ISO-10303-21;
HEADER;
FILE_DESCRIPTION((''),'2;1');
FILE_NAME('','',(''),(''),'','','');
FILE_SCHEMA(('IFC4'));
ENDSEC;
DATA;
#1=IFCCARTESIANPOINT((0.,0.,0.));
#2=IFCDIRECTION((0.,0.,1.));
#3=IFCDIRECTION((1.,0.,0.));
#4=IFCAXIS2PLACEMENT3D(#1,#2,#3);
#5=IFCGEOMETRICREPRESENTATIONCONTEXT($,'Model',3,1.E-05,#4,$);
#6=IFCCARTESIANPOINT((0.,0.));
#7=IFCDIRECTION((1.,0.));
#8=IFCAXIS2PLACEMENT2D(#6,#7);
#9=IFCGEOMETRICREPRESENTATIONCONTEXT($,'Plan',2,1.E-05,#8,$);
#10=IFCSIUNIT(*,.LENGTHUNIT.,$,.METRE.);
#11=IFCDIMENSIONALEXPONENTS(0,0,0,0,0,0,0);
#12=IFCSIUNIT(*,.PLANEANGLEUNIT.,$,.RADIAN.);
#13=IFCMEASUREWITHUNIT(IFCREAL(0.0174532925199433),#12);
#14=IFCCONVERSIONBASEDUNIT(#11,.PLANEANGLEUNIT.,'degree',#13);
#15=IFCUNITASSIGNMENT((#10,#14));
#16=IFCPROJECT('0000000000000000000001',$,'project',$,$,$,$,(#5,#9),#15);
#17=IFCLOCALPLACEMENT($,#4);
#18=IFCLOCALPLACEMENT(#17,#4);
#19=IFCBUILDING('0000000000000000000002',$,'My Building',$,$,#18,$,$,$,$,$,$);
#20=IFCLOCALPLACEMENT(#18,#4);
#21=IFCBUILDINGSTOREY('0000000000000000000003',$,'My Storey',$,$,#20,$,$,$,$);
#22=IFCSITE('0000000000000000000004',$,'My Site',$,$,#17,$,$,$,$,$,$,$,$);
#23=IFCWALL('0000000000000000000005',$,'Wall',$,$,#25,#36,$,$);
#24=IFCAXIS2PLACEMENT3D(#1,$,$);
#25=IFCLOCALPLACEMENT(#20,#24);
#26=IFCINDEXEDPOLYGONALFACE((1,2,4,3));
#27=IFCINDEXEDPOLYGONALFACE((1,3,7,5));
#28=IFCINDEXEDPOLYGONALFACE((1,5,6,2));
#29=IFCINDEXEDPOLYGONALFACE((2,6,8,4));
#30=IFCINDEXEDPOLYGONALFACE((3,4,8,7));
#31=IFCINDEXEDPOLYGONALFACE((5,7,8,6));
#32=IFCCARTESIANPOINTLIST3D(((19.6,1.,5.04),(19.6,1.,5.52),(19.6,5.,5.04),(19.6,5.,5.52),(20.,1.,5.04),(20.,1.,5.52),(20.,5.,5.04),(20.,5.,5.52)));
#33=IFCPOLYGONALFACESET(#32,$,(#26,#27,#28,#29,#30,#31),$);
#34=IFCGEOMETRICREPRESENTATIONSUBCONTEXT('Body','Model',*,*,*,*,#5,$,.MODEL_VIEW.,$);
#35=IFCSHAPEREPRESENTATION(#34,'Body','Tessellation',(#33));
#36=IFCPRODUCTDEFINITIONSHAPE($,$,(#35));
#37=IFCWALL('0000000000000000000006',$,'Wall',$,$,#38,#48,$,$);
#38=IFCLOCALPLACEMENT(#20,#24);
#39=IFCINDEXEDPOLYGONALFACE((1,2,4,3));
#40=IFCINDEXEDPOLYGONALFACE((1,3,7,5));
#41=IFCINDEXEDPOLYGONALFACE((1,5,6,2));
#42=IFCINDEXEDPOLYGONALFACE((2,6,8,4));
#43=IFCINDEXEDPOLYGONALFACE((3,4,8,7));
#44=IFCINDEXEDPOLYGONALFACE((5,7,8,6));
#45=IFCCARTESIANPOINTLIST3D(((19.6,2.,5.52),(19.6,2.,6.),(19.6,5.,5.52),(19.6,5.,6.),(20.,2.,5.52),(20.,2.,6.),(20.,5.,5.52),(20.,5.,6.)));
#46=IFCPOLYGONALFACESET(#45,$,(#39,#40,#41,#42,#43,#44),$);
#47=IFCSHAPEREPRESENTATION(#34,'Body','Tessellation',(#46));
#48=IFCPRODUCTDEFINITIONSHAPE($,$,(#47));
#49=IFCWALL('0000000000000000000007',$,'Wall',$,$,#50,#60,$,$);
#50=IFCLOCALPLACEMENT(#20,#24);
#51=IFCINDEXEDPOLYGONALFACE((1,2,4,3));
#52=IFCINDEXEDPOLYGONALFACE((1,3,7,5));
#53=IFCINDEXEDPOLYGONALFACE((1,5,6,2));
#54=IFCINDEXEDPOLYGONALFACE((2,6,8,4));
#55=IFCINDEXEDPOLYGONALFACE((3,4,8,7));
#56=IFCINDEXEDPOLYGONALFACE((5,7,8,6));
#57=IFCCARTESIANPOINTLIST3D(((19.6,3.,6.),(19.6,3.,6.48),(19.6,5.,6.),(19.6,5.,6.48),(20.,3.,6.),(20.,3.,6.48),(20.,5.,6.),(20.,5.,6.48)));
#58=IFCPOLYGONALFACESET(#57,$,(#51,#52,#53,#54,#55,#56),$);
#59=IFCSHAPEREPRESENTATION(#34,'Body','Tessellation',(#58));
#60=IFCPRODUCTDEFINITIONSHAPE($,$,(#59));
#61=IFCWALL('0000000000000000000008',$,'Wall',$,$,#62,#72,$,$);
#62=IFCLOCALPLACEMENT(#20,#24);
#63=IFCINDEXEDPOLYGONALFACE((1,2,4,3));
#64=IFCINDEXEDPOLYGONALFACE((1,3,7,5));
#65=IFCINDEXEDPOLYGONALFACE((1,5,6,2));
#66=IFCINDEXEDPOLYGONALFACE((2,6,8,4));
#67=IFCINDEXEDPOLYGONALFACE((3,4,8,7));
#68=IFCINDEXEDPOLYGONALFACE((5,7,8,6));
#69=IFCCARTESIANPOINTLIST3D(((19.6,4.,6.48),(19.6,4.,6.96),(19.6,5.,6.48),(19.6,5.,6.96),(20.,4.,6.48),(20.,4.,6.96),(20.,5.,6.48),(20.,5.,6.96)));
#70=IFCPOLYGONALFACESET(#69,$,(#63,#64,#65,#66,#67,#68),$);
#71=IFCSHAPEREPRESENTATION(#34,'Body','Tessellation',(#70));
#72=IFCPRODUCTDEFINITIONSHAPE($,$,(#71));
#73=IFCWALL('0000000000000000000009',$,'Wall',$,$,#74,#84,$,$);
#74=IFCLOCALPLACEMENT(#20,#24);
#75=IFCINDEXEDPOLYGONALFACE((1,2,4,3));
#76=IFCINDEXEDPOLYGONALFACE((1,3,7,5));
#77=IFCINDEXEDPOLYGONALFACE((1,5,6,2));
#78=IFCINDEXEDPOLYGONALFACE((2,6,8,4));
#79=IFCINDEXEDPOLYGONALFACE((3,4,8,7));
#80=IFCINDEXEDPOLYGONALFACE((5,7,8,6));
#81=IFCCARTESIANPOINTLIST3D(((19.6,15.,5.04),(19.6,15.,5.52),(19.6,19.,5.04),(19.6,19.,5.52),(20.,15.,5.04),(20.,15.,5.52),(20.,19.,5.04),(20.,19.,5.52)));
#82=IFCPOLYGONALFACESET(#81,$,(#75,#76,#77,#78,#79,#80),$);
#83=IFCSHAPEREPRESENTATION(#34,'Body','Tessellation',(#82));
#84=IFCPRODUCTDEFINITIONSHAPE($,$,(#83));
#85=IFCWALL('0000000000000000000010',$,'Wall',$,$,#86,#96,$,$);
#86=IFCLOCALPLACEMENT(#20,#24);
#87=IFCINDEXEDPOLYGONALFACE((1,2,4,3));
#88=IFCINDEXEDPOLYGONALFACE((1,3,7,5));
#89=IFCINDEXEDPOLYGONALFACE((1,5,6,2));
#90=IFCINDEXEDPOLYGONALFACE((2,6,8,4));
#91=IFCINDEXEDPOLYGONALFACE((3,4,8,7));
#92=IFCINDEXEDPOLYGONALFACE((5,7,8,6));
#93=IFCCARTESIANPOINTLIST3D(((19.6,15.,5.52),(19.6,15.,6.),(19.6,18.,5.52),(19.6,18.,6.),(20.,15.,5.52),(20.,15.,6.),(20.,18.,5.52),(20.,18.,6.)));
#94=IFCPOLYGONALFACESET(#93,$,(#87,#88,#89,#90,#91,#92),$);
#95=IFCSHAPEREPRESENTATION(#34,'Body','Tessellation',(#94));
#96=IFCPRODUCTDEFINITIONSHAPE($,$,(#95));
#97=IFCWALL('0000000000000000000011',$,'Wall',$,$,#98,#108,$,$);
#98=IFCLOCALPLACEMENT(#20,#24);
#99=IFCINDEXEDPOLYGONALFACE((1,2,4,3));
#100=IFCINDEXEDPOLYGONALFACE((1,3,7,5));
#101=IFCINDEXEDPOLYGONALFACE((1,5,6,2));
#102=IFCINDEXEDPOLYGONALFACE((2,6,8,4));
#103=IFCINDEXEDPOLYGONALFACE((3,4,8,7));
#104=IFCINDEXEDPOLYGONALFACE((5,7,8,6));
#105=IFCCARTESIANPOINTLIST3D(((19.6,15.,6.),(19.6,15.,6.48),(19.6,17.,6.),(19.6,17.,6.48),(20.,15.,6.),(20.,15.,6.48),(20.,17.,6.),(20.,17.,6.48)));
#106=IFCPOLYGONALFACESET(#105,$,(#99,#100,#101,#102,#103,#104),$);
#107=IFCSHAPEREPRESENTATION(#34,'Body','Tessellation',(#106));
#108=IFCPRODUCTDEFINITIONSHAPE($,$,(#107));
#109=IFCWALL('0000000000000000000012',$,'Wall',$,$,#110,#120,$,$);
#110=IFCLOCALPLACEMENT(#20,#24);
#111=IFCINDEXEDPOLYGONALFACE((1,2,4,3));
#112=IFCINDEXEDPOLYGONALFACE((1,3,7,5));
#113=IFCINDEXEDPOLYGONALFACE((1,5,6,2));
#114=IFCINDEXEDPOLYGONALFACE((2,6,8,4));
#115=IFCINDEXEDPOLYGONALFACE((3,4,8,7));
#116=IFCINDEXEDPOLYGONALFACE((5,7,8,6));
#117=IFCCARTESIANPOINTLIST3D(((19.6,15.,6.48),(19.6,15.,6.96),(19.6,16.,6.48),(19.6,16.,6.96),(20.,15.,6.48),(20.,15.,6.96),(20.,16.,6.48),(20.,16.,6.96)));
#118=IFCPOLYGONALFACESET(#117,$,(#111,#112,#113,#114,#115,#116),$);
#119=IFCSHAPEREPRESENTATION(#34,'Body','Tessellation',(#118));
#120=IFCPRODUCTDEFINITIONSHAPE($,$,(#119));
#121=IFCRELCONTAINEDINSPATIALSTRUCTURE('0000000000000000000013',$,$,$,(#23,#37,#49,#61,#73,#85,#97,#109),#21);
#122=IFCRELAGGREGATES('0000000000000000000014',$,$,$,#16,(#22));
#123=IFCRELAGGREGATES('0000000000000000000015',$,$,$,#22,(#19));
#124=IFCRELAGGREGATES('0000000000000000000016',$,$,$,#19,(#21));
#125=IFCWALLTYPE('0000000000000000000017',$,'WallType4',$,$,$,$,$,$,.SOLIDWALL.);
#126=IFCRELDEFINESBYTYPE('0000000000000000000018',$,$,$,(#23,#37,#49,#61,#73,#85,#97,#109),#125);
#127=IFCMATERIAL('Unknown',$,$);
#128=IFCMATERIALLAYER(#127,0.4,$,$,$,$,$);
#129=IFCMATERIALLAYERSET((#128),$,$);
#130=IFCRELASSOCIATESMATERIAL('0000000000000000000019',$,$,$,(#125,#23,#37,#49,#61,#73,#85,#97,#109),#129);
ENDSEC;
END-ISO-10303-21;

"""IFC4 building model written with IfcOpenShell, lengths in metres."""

from ifc_helpers import new_model, entity, si_unit, converted_unit, frame, origin_with_axes, origin_2d_with_axis, place, context, subcontext, project, spatial, indexed_curve, outline, extrude, material, layer, layer_set, layer_usage, type_object, element, save


model = new_model("IFC4")

# Units and contexts
model_context = context("Model", 3, precision=1e-05, world=origin_with_axes())
plan_context = context("Plan", 2, precision=1e-05, world=origin_2d_with_axis())
body_context_1 = subcontext(model_context, "Body", "Model", "MODEL_VIEW")
ifc_project = project(units=[si_unit("LENGTHUNIT", "METRE"), converted_unit("PLANEANGLEUNIT", "degree", entity("IfcReal", 0.0174532925199433), si_unit("PLANEANGLEUNIT", "RADIAN"), dimensions=[0, 0, 0, 0, 0, 0, 0])], contexts=[model_context, plan_context])

# Site, building, storey
site_placement = place(None, origin_with_axes())
site = spatial("IfcSite", under=ifc_project, at=site_placement, Name="My Site")
building_placement = place(site_placement, origin_with_axes())
building = spatial("IfcBuilding", under=site, at=building_placement, Name="My Building")
storey_placement = place(building_placement, origin_with_axes())
storey = spatial("IfcBuildingStorey", under=building, at=storey_placement, Name="My Storey")

# Shared definitions
ifc_material = material(Name="Unknown")

# Shared definitions
ifc_layer_1 = layer(ifc_material, 0.4)
ifc_layer_set_1 = layer_set([ifc_layer_1])
wall_type_1 = type_object("IfcWallType", Name="WallType4", PredefinedType="SOLIDWALL", material=ifc_layer_set_1)

# Walls
ifc_layer_usage_1 = layer_usage(ifc_layer_set_1, "AXIS2", "POSITIVE", 0.0)
wall_1_placement = place(storey_placement, frame((20.0, 1.0, 5.04), z_axis=(0.0, 0.0, 1.0), x_axis=(0.0, 1.0, 0.0)))
element("IfcWall", 1, at=wall_1_placement, inside=storey, type_object=wall_type_1, material=ifc_layer_usage_1, Name="Wall", context=body_context_1, shape_type="SweptSolid", body=[
    extrude(outline(indexed_curve([(0.0, 0.0), (0.0, 0.4), (4.0, 0.4), (4.0, 0.0), (0.0, 0.0)], self_intersect=False)), origin_with_axes(), (0.0, 0.0, 1.0), 0.48),
])
ifc_layer_usage_2 = layer_usage(ifc_layer_set_1, "AXIS2", "POSITIVE", 0.0)
wall_2_placement = place(storey_placement, frame((20.0, 2.0, 5.52), z_axis=(0.0, 0.0, 1.0), x_axis=(0.0, 1.0, 0.0)))
element("IfcWall", 2, at=wall_2_placement, inside=storey, type_object=wall_type_1, material=ifc_layer_usage_2, Name="Wall", context=body_context_1, shape_type="SweptSolid", body=[
    extrude(outline(indexed_curve([(0.0, 0.0), (0.0, 0.4), (3.0, 0.4), (3.0, 0.0), (0.0, 0.0)], self_intersect=False)), origin_with_axes(), (0.0, 0.0, 1.0), 0.48),
])
ifc_layer_usage_3 = layer_usage(ifc_layer_set_1, "AXIS2", "POSITIVE", 0.0)
wall_3_placement = place(storey_placement, frame((20.0, 3.0, 6.0), z_axis=(0.0, 0.0, 1.0), x_axis=(0.0, 1.0, 0.0)))
element("IfcWall", 3, at=wall_3_placement, inside=storey, type_object=wall_type_1, material=ifc_layer_usage_3, Name="Wall", context=body_context_1, shape_type="SweptSolid", body=[
    extrude(outline(indexed_curve([(0.0, 0.0), (0.0, 0.4), (2.0, 0.4), (2.0, 0.0), (0.0, 0.0)], self_intersect=False)), origin_with_axes(), (0.0, 0.0, 1.0), 0.48),
])
ifc_layer_usage_4 = layer_usage(ifc_layer_set_1, "AXIS2", "POSITIVE", 0.0)
wall_4_placement = place(storey_placement, frame((20.0, 4.0, 6.48), z_axis=(0.0, 0.0, 1.0), x_axis=(0.0, 1.0, 0.0)))
element("IfcWall", 4, at=wall_4_placement, inside=storey, type_object=wall_type_1, material=ifc_layer_usage_4, Name="Wall", context=body_context_1, shape_type="SweptSolid", body=[
    extrude(outline(indexed_curve([(0.0, 0.0), (0.0, 0.4), (1.0, 0.4), (1.0, 0.0), (0.0, 0.0)], self_intersect=False)), origin_with_axes(), (0.0, 0.0, 1.0), 0.48),
])
ifc_layer_usage_5 = layer_usage(ifc_layer_set_1, "AXIS2", "POSITIVE", 0.0)
wall_5_placement = place(storey_placement, frame((20.0, 15.0, 5.04), z_axis=(0.0, 0.0, 1.0), x_axis=(0.0, 1.0, 0.0)))
element("IfcWall", 5, at=wall_5_placement, inside=storey, type_object=wall_type_1, material=ifc_layer_usage_5, Name="Wall", context=body_context_1, shape_type="SweptSolid", body=[
    extrude(outline(indexed_curve([(0.0, 0.0), (0.0, 0.4), (4.0, 0.4), (4.0, 0.0), (0.0, 0.0)], self_intersect=False)), origin_with_axes(), (0.0, 0.0, 1.0), 0.48),
])
ifc_layer_usage_6 = layer_usage(ifc_layer_set_1, "AXIS2", "POSITIVE", 0.0)
wall_6_placement = place(storey_placement, frame((20.0, 15.0, 5.52), z_axis=(0.0, 0.0, 1.0), x_axis=(0.0, 1.0, 0.0)))
element("IfcWall", 6, at=wall_6_placement, inside=storey, type_object=wall_type_1, material=ifc_layer_usage_6, Name="Wall", context=body_context_1, shape_type="SweptSolid", body=[
    extrude(outline(indexed_curve([(0.0, 0.0), (0.0, 0.4), (3.0, 0.4), (3.0, 0.0), (0.0, 0.0)], self_intersect=False)), origin_with_axes(), (0.0, 0.0, 1.0), 0.48),
])
ifc_layer_usage_7 = layer_usage(ifc_layer_set_1, "AXIS2", "POSITIVE", 0.0)
wall_7_placement = place(storey_placement, frame((20.0, 15.0, 6.0), z_axis=(0.0, 0.0, 1.0), x_axis=(0.0, 1.0, 0.0)))
element("IfcWall", 7, at=wall_7_placement, inside=storey, type_object=wall_type_1, material=ifc_layer_usage_7, Name="Wall", context=body_context_1, shape_type="SweptSolid", body=[
    extrude(outline(indexed_curve([(0.0, 0.0), (0.0, 0.4), (2.0, 0.4), (2.0, 0.0), (0.0, 0.0)], self_intersect=False)), origin_with_axes(), (0.0, 0.0, 1.0), 0.48),
])
ifc_layer_usage_8 = layer_usage(ifc_layer_set_1, "AXIS2", "POSITIVE", 0.0)
wall_8_placement = place(storey_placement, frame((20.0, 15.0, 6.48), z_axis=(0.0, 0.0, 1.0), x_axis=(0.0, 1.0, 0.0)))
element("IfcWall", 8, at=wall_8_placement, inside=storey, type_object=wall_type_1, material=ifc_layer_usage_8, Name="Wall", context=body_context_1, shape_type="SweptSolid", body=[
    extrude(outline(indexed_curve([(0.0, 0.0), (0.0, 0.4), (1.0, 0.4), (1.0, 0.0), (0.0, 0.0)], self_intersect=False)), origin_with_axes(), (0.0, 0.0, 1.0), 0.48),
])

save(model, "model.ifc")
